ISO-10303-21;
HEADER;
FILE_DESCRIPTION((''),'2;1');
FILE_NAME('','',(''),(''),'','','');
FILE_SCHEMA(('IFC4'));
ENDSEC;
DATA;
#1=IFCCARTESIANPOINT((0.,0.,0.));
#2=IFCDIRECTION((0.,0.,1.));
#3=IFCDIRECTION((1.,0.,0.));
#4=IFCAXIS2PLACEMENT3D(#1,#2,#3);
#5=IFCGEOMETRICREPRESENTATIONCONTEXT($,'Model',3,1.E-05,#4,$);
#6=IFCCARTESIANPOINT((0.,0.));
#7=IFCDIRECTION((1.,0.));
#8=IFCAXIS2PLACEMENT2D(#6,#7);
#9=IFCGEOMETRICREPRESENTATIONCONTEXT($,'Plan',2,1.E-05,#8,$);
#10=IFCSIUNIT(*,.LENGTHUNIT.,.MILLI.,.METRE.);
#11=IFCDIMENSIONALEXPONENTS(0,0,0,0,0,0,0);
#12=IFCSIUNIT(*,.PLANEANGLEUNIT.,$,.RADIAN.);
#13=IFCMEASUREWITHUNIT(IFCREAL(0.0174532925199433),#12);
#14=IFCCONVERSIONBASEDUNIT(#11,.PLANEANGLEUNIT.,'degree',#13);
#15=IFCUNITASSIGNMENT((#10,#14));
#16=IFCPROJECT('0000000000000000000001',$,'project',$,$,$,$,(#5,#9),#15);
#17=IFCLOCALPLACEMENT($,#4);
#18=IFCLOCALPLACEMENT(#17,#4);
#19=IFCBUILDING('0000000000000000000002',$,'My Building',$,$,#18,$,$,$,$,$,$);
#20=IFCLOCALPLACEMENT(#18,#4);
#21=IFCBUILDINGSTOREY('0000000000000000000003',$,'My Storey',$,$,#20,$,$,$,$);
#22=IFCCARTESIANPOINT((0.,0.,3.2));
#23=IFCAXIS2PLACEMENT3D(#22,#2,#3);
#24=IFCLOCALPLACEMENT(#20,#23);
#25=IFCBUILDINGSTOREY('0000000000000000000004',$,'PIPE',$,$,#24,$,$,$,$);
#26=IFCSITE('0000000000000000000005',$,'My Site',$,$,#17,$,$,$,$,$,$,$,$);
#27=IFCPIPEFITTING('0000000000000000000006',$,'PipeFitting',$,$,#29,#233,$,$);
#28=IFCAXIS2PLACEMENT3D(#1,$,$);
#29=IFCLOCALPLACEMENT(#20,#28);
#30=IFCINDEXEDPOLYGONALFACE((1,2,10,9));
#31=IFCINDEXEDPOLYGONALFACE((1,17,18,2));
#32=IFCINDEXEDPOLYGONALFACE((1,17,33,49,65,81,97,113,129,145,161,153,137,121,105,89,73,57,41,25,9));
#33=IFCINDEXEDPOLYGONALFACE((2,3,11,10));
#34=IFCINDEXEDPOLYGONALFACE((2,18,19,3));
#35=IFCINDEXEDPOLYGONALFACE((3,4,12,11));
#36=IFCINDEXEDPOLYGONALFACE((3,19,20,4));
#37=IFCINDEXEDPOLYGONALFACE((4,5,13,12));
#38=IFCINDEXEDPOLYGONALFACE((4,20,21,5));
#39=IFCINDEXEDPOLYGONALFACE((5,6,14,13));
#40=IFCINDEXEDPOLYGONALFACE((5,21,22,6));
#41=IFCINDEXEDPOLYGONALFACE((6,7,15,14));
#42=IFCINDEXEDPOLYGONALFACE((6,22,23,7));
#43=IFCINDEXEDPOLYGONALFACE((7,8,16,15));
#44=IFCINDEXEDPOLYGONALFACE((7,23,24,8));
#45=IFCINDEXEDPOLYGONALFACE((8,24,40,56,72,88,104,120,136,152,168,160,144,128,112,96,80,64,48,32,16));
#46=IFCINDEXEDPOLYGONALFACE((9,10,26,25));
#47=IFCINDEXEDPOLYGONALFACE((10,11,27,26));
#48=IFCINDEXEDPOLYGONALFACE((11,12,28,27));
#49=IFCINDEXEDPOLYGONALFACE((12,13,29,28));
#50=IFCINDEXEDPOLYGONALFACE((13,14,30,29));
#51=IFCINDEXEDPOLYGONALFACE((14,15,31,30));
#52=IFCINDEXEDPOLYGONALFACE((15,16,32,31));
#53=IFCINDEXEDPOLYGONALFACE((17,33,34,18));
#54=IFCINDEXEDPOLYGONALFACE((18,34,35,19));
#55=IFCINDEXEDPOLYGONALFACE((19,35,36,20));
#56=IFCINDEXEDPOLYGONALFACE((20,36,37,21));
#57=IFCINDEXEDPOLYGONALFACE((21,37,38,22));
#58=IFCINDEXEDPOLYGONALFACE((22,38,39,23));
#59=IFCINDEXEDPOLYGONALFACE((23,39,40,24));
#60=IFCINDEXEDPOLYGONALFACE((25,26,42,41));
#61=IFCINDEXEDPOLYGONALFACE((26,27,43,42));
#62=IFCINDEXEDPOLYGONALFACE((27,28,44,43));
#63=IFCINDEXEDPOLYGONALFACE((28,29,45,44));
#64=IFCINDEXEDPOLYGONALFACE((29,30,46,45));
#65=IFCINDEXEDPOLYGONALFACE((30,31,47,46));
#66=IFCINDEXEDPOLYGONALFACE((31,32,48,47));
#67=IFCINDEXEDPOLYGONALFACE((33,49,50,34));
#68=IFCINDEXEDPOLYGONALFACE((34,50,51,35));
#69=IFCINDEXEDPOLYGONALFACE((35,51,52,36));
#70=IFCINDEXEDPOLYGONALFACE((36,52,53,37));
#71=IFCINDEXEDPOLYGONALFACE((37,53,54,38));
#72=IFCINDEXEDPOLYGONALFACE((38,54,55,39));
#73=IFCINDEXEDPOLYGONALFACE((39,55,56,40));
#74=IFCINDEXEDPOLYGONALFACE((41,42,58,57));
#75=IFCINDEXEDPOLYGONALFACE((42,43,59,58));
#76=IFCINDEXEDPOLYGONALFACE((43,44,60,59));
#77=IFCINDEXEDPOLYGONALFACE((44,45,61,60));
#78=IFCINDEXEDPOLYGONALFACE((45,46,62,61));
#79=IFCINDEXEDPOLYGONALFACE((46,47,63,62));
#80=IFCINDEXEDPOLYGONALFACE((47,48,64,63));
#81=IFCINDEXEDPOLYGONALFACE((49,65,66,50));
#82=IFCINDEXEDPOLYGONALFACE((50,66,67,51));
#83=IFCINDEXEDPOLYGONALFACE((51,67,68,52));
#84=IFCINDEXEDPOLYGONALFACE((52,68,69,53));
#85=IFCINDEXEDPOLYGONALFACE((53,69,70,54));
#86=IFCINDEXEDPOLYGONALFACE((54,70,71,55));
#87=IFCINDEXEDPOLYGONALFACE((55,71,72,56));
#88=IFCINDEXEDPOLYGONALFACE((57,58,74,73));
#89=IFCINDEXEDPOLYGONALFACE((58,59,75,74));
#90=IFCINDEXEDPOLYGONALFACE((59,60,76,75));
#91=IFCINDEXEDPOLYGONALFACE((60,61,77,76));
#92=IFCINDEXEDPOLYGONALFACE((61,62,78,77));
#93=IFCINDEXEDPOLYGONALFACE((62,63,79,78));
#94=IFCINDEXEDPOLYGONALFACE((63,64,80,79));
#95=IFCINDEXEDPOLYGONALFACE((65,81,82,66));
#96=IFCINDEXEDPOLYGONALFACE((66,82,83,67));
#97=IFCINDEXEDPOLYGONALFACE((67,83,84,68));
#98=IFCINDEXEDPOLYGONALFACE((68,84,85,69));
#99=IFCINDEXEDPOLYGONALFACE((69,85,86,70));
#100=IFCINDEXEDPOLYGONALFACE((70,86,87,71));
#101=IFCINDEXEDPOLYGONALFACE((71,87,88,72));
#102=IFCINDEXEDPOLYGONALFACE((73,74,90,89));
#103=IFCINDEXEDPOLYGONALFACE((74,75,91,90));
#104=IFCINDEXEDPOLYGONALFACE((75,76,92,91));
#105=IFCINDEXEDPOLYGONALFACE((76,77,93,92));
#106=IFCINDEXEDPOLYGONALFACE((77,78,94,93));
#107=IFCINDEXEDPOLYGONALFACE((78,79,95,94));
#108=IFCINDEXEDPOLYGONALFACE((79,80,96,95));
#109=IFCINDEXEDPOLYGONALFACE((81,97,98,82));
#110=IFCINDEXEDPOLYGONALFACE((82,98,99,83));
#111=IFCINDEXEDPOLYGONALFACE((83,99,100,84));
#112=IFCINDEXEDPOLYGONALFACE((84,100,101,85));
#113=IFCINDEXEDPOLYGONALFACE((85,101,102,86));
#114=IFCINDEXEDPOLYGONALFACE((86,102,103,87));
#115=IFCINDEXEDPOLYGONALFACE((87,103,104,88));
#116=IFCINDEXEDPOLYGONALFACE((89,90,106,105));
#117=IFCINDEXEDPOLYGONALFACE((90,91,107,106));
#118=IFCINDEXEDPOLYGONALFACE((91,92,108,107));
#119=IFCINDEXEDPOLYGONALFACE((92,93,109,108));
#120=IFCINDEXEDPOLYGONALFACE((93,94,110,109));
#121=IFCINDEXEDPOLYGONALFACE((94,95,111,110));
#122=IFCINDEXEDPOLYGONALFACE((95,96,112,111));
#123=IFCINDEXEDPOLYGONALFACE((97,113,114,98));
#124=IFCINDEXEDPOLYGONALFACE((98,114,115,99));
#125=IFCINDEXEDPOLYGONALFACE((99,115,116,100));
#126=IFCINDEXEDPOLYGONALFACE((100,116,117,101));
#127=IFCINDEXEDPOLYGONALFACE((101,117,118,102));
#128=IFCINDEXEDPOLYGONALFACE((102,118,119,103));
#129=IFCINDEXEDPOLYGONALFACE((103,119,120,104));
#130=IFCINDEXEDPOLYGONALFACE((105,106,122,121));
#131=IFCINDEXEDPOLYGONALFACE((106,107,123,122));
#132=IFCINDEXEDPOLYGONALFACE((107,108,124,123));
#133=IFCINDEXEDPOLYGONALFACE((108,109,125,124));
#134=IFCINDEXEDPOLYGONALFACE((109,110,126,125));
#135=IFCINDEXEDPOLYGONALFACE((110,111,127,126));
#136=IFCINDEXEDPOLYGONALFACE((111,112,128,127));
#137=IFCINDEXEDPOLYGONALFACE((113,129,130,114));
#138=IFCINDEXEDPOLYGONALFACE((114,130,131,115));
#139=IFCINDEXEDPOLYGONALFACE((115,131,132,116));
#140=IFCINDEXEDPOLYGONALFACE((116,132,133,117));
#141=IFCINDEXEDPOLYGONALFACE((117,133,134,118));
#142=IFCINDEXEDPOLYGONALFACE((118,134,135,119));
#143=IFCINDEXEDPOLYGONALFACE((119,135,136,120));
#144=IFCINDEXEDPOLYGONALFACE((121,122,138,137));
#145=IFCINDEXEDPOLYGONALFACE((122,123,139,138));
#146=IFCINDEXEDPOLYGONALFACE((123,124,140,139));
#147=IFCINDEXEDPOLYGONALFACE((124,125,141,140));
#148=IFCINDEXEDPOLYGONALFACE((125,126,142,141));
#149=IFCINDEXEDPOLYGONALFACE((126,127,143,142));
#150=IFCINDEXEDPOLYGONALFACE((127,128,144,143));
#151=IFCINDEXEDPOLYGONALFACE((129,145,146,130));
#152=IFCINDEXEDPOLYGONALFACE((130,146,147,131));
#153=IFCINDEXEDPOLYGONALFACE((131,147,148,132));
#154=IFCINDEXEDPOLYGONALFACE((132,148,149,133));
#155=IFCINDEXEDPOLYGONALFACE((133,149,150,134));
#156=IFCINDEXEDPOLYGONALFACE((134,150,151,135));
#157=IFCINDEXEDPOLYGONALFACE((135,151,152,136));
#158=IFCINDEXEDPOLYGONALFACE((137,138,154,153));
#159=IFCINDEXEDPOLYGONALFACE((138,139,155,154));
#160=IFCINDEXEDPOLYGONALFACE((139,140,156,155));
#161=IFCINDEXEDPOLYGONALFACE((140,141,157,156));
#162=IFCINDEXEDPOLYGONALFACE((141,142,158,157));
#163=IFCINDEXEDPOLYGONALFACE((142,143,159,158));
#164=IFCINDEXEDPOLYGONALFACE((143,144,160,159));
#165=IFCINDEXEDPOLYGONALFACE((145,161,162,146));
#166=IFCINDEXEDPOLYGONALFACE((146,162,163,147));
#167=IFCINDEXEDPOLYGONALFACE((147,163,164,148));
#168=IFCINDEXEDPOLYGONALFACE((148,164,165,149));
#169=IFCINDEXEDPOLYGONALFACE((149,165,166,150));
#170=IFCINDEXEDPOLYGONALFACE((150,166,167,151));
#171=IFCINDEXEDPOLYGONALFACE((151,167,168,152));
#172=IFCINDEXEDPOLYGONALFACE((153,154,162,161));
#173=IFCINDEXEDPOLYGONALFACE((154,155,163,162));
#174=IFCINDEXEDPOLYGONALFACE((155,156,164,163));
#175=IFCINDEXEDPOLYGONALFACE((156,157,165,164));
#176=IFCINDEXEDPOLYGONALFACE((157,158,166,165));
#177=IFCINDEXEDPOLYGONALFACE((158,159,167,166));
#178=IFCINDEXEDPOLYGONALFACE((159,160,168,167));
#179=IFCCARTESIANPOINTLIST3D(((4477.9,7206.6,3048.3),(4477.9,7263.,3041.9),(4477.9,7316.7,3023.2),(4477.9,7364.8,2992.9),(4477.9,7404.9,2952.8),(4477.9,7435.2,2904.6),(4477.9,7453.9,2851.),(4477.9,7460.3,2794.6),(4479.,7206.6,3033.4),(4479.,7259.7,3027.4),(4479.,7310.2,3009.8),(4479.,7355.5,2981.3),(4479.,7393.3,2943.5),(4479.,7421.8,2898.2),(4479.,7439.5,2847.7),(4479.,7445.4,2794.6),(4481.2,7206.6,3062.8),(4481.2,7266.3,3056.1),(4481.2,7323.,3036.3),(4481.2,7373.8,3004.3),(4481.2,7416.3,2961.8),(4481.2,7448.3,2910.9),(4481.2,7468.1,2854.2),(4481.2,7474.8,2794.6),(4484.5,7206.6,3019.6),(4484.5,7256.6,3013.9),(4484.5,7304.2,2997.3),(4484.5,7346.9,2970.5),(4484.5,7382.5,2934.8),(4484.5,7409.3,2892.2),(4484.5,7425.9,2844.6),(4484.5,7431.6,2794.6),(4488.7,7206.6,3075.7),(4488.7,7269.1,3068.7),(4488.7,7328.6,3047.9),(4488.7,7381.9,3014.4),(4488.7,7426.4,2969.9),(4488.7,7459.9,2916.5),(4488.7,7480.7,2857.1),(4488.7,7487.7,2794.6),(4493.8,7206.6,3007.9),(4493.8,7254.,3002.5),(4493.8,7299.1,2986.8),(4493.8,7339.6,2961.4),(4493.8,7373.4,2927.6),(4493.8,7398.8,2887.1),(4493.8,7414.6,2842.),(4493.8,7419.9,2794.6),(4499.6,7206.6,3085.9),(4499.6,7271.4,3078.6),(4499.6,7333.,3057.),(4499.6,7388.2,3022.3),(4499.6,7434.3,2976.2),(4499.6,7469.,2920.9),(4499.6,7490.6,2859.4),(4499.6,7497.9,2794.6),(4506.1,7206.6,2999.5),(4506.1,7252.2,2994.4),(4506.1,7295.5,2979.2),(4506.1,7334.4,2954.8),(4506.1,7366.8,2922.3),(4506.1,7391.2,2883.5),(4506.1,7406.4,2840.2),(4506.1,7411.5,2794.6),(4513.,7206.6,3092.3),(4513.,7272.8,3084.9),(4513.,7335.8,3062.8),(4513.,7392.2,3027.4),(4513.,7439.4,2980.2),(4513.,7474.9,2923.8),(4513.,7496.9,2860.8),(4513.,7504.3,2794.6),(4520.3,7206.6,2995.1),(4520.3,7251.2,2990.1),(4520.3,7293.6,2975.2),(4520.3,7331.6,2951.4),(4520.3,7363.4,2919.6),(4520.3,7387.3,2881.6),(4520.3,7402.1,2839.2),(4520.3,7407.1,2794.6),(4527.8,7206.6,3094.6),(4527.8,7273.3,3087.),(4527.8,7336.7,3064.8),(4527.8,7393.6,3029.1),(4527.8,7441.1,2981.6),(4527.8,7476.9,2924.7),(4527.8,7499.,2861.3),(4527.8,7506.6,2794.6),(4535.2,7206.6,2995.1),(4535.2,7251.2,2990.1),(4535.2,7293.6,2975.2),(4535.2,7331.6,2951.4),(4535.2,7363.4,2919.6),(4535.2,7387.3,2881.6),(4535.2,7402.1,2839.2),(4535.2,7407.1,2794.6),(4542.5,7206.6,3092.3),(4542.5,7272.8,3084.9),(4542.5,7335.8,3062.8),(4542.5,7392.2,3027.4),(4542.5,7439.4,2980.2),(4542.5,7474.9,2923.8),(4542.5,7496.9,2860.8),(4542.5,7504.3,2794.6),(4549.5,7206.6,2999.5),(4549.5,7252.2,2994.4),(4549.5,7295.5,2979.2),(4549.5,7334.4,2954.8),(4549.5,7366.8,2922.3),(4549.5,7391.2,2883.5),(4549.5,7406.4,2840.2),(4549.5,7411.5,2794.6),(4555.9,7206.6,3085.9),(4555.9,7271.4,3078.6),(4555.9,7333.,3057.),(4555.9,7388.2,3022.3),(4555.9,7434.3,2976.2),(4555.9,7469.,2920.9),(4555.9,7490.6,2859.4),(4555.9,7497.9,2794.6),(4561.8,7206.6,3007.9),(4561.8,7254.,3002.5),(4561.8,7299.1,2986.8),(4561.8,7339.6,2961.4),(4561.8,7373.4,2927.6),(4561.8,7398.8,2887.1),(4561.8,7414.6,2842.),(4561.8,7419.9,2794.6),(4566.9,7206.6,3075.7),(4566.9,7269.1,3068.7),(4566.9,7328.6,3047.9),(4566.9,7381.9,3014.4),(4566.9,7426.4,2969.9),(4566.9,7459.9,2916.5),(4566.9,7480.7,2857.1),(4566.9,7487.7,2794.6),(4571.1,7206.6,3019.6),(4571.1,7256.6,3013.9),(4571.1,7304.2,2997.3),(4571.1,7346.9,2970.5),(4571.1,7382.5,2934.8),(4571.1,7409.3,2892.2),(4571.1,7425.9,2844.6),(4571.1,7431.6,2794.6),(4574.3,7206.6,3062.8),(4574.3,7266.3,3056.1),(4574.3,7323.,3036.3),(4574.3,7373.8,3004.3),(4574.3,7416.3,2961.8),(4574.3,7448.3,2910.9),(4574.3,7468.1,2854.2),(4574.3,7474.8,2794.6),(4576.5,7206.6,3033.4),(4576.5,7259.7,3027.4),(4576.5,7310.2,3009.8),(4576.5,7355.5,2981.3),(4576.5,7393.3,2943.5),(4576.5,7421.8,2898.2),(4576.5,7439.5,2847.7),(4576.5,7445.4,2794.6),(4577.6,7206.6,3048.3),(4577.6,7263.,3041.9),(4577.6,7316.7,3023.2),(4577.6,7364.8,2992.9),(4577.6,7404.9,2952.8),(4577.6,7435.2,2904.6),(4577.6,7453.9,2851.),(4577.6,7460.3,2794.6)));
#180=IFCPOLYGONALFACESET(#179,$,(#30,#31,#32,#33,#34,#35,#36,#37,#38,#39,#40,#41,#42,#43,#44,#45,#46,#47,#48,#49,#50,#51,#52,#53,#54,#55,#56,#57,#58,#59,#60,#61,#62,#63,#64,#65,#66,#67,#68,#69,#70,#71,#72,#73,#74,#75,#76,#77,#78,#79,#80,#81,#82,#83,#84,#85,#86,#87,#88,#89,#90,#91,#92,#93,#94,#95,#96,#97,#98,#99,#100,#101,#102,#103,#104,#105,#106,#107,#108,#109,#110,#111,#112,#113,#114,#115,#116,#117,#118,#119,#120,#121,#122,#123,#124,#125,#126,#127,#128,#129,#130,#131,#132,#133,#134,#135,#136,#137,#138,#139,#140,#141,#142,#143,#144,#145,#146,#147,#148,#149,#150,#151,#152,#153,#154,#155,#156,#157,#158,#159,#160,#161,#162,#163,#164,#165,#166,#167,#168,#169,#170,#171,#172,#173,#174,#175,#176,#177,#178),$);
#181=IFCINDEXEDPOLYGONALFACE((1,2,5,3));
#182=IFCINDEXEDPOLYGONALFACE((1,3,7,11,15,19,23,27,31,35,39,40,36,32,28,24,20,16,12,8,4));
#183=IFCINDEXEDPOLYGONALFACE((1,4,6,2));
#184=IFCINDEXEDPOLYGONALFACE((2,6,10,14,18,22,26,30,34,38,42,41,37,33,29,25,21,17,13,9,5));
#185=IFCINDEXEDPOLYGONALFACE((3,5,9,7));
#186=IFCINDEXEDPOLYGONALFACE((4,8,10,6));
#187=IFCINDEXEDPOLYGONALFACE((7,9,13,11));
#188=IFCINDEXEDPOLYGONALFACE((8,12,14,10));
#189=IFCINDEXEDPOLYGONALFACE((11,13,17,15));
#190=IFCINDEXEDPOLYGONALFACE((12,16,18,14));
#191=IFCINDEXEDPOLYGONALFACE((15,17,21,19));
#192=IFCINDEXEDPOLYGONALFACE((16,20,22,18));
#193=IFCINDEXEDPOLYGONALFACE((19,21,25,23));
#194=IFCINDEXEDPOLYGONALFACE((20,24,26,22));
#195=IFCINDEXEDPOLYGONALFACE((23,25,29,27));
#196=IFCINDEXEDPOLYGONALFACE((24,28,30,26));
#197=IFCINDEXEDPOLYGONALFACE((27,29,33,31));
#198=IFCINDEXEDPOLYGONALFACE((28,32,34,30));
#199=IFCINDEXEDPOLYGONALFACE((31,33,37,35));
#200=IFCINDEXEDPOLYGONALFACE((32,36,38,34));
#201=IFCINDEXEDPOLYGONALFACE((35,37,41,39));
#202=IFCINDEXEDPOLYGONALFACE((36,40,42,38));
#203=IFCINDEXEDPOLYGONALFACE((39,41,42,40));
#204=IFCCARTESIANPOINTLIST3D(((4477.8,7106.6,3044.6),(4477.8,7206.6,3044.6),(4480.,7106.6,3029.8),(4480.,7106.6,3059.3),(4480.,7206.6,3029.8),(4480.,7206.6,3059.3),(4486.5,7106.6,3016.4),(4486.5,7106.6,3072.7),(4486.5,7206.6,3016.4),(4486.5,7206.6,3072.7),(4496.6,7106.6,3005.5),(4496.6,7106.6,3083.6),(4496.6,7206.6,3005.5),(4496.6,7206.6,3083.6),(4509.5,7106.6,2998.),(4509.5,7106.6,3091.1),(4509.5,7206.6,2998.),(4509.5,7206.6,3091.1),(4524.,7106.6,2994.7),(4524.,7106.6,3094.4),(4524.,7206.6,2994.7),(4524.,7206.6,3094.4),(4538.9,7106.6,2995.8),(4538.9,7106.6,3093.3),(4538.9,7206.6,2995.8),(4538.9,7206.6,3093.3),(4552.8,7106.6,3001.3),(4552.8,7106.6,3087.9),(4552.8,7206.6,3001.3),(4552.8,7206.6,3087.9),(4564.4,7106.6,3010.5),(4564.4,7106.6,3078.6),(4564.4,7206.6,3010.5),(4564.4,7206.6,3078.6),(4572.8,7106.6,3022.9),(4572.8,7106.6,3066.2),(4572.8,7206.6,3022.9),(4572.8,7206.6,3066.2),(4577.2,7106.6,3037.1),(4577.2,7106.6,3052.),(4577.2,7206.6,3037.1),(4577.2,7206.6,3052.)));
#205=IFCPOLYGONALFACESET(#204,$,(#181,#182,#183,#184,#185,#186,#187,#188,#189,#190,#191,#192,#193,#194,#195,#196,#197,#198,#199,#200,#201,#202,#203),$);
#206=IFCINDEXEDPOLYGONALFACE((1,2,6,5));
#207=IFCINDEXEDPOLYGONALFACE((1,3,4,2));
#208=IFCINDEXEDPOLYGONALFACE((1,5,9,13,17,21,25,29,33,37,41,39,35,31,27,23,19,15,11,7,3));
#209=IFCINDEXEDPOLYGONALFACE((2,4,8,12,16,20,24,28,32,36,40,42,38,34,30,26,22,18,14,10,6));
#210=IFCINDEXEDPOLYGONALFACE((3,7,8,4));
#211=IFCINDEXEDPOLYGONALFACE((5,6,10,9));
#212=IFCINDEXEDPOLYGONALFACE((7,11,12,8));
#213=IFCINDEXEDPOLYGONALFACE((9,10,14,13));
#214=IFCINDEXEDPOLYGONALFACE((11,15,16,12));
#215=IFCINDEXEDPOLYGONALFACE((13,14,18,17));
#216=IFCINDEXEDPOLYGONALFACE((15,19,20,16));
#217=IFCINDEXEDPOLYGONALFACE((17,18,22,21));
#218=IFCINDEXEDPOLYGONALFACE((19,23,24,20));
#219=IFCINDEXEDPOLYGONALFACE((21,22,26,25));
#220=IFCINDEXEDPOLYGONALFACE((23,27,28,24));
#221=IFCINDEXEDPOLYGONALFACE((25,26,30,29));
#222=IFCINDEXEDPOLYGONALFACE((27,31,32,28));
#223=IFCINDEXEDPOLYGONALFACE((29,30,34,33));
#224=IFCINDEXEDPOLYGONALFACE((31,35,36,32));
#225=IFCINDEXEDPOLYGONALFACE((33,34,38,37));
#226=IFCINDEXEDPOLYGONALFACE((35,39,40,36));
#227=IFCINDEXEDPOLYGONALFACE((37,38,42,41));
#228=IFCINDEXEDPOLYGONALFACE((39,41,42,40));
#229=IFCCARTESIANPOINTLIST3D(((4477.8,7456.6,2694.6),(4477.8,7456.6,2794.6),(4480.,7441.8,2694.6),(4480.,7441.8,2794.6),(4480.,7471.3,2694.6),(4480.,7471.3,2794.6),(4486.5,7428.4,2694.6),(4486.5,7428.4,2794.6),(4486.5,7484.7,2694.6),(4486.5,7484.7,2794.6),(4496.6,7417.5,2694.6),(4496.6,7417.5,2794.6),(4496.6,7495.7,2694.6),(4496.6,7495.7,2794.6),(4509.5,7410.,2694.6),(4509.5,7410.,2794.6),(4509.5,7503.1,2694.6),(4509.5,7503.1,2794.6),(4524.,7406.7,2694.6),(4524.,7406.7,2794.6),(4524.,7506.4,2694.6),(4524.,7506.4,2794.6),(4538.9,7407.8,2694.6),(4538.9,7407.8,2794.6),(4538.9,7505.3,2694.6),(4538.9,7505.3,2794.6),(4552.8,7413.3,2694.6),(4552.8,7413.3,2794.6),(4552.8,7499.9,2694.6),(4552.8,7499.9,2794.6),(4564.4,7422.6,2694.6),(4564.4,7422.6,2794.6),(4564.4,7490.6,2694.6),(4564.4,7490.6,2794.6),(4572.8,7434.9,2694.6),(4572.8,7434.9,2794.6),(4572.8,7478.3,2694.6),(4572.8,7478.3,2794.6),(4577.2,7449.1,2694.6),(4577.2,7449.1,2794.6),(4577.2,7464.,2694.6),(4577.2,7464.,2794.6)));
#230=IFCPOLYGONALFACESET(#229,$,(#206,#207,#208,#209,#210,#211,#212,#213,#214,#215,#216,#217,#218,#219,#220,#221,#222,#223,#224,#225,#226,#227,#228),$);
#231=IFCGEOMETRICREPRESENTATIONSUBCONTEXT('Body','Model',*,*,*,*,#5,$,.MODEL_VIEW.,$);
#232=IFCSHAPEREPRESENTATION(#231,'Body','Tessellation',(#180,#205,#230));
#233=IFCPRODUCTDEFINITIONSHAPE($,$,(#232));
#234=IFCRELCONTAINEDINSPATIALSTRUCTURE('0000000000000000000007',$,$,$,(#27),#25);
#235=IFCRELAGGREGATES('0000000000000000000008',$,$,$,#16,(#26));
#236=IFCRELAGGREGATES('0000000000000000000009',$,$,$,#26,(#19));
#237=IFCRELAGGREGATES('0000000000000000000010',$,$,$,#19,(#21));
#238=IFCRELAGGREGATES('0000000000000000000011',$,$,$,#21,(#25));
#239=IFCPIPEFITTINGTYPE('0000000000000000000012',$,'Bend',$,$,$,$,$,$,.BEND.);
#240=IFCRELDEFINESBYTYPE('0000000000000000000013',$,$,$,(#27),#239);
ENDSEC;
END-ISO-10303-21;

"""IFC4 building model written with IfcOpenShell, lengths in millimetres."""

from ifc_helpers import new_model, entity, si_unit, converted_unit, frame, origin_with_axes, origin_2d_with_axis, place, context, subcontext, project, spatial, circle, extrude, source, transform, mapped, type_object, type_shapes, element, save


model = new_model("IFC4")

# Units and contexts
model_context = context("Model", 3, precision=1e-05, world=origin_with_axes())
plan_context = context("Plan", 2, precision=1e-05, world=origin_2d_with_axis())
body_context = subcontext(model_context, "Body", "Model", "MODEL_VIEW")
ifc_project = project(units=[si_unit("LENGTHUNIT", "METRE", prefix="MILLI"), converted_unit("PLANEANGLEUNIT", "degree", entity("IfcReal", 0.0174532925199433), si_unit("PLANEANGLEUNIT", "RADIAN"), dimensions=[0, 0, 0, 0, 0, 0, 0])], contexts=[model_context, plan_context])

# Site, building, storeys
site_placement = place(None, origin_with_axes())
site = spatial("IfcSite", under=ifc_project, at=site_placement, Name="My Site")
building_placement = place(site_placement, origin_with_axes())
building = spatial("IfcBuilding", under=site, at=building_placement, Name="My Building")
storey_1_placement = place(building_placement, origin_with_axes())
storey_1 = spatial("IfcBuildingStorey", under=building, at=storey_1_placement, Name="My Storey")
storey_2_placement = place(storey_1_placement, frame((0.0, 0.0, 3.2), z_axis=(0.0, 0.0, 1.0), x_axis=(1.0, 0.0, 0.0)))
storey_2 = spatial("IfcBuildingStorey", under=storey_1, at=storey_2_placement, Name="PIPE")

# Pipe fitting
pipe_fitting_type = type_object("IfcPipeFittingType", Name="Bend", PredefinedType="BEND")
shared_shape = source(origin_with_axes(), body_context, "Body", "SolidModel", [
    entity("IfcSweptDiskSolid", entity("IfcIndexedPolyCurve", entity("IfcCartesianPointList3D", [[0.0, 0.0, 100.0], [0.0, -73.2, 276.8], [0.0, -250.0, 350.0]]), [entity("IfcArcIndex", [1, 2, 3])]), 50.0),
    extrude(circle(Radius=50.0), origin_with_axes(), (0.0, 0.0, 1.0), 100.0),
    extrude(circle(Radius=50.0), frame((0.0, -250.0, 350.0), z_axis=(0.0, -1.0, 0.0), x_axis=(1.0, 0.0, 0.0)), (0.0, 0.0, 1.0), 100.0),
])
type_shapes(pipe_fitting_type, [shared_shape])
for number, where, z_axis, x_axis, name in (
    (1, (4527.8, 7106.6, 3041.4), (0.0, 1.0, 0.0), (-1.0, 0.0, 0.0), "PipeFitting"),
):
    element("IfcPipeFitting", number, at=place(storey_2_placement, frame(where, z_axis=z_axis, x_axis=x_axis)), inside=storey_2, type_object=pipe_fitting_type, Name=name, context=body_context, shape_type="MappedRepresentation", body=[
        mapped(shared_shape, transform((0.0, 0.0, 0.0), x_axis=(1.0, 0.0, 0.0), y_axis=(0.0, 1.0, 0.0), z_axis=(0.0, 0.0, 1.0), scale=1.0)),
    ])

save(model, "model.ifc")
